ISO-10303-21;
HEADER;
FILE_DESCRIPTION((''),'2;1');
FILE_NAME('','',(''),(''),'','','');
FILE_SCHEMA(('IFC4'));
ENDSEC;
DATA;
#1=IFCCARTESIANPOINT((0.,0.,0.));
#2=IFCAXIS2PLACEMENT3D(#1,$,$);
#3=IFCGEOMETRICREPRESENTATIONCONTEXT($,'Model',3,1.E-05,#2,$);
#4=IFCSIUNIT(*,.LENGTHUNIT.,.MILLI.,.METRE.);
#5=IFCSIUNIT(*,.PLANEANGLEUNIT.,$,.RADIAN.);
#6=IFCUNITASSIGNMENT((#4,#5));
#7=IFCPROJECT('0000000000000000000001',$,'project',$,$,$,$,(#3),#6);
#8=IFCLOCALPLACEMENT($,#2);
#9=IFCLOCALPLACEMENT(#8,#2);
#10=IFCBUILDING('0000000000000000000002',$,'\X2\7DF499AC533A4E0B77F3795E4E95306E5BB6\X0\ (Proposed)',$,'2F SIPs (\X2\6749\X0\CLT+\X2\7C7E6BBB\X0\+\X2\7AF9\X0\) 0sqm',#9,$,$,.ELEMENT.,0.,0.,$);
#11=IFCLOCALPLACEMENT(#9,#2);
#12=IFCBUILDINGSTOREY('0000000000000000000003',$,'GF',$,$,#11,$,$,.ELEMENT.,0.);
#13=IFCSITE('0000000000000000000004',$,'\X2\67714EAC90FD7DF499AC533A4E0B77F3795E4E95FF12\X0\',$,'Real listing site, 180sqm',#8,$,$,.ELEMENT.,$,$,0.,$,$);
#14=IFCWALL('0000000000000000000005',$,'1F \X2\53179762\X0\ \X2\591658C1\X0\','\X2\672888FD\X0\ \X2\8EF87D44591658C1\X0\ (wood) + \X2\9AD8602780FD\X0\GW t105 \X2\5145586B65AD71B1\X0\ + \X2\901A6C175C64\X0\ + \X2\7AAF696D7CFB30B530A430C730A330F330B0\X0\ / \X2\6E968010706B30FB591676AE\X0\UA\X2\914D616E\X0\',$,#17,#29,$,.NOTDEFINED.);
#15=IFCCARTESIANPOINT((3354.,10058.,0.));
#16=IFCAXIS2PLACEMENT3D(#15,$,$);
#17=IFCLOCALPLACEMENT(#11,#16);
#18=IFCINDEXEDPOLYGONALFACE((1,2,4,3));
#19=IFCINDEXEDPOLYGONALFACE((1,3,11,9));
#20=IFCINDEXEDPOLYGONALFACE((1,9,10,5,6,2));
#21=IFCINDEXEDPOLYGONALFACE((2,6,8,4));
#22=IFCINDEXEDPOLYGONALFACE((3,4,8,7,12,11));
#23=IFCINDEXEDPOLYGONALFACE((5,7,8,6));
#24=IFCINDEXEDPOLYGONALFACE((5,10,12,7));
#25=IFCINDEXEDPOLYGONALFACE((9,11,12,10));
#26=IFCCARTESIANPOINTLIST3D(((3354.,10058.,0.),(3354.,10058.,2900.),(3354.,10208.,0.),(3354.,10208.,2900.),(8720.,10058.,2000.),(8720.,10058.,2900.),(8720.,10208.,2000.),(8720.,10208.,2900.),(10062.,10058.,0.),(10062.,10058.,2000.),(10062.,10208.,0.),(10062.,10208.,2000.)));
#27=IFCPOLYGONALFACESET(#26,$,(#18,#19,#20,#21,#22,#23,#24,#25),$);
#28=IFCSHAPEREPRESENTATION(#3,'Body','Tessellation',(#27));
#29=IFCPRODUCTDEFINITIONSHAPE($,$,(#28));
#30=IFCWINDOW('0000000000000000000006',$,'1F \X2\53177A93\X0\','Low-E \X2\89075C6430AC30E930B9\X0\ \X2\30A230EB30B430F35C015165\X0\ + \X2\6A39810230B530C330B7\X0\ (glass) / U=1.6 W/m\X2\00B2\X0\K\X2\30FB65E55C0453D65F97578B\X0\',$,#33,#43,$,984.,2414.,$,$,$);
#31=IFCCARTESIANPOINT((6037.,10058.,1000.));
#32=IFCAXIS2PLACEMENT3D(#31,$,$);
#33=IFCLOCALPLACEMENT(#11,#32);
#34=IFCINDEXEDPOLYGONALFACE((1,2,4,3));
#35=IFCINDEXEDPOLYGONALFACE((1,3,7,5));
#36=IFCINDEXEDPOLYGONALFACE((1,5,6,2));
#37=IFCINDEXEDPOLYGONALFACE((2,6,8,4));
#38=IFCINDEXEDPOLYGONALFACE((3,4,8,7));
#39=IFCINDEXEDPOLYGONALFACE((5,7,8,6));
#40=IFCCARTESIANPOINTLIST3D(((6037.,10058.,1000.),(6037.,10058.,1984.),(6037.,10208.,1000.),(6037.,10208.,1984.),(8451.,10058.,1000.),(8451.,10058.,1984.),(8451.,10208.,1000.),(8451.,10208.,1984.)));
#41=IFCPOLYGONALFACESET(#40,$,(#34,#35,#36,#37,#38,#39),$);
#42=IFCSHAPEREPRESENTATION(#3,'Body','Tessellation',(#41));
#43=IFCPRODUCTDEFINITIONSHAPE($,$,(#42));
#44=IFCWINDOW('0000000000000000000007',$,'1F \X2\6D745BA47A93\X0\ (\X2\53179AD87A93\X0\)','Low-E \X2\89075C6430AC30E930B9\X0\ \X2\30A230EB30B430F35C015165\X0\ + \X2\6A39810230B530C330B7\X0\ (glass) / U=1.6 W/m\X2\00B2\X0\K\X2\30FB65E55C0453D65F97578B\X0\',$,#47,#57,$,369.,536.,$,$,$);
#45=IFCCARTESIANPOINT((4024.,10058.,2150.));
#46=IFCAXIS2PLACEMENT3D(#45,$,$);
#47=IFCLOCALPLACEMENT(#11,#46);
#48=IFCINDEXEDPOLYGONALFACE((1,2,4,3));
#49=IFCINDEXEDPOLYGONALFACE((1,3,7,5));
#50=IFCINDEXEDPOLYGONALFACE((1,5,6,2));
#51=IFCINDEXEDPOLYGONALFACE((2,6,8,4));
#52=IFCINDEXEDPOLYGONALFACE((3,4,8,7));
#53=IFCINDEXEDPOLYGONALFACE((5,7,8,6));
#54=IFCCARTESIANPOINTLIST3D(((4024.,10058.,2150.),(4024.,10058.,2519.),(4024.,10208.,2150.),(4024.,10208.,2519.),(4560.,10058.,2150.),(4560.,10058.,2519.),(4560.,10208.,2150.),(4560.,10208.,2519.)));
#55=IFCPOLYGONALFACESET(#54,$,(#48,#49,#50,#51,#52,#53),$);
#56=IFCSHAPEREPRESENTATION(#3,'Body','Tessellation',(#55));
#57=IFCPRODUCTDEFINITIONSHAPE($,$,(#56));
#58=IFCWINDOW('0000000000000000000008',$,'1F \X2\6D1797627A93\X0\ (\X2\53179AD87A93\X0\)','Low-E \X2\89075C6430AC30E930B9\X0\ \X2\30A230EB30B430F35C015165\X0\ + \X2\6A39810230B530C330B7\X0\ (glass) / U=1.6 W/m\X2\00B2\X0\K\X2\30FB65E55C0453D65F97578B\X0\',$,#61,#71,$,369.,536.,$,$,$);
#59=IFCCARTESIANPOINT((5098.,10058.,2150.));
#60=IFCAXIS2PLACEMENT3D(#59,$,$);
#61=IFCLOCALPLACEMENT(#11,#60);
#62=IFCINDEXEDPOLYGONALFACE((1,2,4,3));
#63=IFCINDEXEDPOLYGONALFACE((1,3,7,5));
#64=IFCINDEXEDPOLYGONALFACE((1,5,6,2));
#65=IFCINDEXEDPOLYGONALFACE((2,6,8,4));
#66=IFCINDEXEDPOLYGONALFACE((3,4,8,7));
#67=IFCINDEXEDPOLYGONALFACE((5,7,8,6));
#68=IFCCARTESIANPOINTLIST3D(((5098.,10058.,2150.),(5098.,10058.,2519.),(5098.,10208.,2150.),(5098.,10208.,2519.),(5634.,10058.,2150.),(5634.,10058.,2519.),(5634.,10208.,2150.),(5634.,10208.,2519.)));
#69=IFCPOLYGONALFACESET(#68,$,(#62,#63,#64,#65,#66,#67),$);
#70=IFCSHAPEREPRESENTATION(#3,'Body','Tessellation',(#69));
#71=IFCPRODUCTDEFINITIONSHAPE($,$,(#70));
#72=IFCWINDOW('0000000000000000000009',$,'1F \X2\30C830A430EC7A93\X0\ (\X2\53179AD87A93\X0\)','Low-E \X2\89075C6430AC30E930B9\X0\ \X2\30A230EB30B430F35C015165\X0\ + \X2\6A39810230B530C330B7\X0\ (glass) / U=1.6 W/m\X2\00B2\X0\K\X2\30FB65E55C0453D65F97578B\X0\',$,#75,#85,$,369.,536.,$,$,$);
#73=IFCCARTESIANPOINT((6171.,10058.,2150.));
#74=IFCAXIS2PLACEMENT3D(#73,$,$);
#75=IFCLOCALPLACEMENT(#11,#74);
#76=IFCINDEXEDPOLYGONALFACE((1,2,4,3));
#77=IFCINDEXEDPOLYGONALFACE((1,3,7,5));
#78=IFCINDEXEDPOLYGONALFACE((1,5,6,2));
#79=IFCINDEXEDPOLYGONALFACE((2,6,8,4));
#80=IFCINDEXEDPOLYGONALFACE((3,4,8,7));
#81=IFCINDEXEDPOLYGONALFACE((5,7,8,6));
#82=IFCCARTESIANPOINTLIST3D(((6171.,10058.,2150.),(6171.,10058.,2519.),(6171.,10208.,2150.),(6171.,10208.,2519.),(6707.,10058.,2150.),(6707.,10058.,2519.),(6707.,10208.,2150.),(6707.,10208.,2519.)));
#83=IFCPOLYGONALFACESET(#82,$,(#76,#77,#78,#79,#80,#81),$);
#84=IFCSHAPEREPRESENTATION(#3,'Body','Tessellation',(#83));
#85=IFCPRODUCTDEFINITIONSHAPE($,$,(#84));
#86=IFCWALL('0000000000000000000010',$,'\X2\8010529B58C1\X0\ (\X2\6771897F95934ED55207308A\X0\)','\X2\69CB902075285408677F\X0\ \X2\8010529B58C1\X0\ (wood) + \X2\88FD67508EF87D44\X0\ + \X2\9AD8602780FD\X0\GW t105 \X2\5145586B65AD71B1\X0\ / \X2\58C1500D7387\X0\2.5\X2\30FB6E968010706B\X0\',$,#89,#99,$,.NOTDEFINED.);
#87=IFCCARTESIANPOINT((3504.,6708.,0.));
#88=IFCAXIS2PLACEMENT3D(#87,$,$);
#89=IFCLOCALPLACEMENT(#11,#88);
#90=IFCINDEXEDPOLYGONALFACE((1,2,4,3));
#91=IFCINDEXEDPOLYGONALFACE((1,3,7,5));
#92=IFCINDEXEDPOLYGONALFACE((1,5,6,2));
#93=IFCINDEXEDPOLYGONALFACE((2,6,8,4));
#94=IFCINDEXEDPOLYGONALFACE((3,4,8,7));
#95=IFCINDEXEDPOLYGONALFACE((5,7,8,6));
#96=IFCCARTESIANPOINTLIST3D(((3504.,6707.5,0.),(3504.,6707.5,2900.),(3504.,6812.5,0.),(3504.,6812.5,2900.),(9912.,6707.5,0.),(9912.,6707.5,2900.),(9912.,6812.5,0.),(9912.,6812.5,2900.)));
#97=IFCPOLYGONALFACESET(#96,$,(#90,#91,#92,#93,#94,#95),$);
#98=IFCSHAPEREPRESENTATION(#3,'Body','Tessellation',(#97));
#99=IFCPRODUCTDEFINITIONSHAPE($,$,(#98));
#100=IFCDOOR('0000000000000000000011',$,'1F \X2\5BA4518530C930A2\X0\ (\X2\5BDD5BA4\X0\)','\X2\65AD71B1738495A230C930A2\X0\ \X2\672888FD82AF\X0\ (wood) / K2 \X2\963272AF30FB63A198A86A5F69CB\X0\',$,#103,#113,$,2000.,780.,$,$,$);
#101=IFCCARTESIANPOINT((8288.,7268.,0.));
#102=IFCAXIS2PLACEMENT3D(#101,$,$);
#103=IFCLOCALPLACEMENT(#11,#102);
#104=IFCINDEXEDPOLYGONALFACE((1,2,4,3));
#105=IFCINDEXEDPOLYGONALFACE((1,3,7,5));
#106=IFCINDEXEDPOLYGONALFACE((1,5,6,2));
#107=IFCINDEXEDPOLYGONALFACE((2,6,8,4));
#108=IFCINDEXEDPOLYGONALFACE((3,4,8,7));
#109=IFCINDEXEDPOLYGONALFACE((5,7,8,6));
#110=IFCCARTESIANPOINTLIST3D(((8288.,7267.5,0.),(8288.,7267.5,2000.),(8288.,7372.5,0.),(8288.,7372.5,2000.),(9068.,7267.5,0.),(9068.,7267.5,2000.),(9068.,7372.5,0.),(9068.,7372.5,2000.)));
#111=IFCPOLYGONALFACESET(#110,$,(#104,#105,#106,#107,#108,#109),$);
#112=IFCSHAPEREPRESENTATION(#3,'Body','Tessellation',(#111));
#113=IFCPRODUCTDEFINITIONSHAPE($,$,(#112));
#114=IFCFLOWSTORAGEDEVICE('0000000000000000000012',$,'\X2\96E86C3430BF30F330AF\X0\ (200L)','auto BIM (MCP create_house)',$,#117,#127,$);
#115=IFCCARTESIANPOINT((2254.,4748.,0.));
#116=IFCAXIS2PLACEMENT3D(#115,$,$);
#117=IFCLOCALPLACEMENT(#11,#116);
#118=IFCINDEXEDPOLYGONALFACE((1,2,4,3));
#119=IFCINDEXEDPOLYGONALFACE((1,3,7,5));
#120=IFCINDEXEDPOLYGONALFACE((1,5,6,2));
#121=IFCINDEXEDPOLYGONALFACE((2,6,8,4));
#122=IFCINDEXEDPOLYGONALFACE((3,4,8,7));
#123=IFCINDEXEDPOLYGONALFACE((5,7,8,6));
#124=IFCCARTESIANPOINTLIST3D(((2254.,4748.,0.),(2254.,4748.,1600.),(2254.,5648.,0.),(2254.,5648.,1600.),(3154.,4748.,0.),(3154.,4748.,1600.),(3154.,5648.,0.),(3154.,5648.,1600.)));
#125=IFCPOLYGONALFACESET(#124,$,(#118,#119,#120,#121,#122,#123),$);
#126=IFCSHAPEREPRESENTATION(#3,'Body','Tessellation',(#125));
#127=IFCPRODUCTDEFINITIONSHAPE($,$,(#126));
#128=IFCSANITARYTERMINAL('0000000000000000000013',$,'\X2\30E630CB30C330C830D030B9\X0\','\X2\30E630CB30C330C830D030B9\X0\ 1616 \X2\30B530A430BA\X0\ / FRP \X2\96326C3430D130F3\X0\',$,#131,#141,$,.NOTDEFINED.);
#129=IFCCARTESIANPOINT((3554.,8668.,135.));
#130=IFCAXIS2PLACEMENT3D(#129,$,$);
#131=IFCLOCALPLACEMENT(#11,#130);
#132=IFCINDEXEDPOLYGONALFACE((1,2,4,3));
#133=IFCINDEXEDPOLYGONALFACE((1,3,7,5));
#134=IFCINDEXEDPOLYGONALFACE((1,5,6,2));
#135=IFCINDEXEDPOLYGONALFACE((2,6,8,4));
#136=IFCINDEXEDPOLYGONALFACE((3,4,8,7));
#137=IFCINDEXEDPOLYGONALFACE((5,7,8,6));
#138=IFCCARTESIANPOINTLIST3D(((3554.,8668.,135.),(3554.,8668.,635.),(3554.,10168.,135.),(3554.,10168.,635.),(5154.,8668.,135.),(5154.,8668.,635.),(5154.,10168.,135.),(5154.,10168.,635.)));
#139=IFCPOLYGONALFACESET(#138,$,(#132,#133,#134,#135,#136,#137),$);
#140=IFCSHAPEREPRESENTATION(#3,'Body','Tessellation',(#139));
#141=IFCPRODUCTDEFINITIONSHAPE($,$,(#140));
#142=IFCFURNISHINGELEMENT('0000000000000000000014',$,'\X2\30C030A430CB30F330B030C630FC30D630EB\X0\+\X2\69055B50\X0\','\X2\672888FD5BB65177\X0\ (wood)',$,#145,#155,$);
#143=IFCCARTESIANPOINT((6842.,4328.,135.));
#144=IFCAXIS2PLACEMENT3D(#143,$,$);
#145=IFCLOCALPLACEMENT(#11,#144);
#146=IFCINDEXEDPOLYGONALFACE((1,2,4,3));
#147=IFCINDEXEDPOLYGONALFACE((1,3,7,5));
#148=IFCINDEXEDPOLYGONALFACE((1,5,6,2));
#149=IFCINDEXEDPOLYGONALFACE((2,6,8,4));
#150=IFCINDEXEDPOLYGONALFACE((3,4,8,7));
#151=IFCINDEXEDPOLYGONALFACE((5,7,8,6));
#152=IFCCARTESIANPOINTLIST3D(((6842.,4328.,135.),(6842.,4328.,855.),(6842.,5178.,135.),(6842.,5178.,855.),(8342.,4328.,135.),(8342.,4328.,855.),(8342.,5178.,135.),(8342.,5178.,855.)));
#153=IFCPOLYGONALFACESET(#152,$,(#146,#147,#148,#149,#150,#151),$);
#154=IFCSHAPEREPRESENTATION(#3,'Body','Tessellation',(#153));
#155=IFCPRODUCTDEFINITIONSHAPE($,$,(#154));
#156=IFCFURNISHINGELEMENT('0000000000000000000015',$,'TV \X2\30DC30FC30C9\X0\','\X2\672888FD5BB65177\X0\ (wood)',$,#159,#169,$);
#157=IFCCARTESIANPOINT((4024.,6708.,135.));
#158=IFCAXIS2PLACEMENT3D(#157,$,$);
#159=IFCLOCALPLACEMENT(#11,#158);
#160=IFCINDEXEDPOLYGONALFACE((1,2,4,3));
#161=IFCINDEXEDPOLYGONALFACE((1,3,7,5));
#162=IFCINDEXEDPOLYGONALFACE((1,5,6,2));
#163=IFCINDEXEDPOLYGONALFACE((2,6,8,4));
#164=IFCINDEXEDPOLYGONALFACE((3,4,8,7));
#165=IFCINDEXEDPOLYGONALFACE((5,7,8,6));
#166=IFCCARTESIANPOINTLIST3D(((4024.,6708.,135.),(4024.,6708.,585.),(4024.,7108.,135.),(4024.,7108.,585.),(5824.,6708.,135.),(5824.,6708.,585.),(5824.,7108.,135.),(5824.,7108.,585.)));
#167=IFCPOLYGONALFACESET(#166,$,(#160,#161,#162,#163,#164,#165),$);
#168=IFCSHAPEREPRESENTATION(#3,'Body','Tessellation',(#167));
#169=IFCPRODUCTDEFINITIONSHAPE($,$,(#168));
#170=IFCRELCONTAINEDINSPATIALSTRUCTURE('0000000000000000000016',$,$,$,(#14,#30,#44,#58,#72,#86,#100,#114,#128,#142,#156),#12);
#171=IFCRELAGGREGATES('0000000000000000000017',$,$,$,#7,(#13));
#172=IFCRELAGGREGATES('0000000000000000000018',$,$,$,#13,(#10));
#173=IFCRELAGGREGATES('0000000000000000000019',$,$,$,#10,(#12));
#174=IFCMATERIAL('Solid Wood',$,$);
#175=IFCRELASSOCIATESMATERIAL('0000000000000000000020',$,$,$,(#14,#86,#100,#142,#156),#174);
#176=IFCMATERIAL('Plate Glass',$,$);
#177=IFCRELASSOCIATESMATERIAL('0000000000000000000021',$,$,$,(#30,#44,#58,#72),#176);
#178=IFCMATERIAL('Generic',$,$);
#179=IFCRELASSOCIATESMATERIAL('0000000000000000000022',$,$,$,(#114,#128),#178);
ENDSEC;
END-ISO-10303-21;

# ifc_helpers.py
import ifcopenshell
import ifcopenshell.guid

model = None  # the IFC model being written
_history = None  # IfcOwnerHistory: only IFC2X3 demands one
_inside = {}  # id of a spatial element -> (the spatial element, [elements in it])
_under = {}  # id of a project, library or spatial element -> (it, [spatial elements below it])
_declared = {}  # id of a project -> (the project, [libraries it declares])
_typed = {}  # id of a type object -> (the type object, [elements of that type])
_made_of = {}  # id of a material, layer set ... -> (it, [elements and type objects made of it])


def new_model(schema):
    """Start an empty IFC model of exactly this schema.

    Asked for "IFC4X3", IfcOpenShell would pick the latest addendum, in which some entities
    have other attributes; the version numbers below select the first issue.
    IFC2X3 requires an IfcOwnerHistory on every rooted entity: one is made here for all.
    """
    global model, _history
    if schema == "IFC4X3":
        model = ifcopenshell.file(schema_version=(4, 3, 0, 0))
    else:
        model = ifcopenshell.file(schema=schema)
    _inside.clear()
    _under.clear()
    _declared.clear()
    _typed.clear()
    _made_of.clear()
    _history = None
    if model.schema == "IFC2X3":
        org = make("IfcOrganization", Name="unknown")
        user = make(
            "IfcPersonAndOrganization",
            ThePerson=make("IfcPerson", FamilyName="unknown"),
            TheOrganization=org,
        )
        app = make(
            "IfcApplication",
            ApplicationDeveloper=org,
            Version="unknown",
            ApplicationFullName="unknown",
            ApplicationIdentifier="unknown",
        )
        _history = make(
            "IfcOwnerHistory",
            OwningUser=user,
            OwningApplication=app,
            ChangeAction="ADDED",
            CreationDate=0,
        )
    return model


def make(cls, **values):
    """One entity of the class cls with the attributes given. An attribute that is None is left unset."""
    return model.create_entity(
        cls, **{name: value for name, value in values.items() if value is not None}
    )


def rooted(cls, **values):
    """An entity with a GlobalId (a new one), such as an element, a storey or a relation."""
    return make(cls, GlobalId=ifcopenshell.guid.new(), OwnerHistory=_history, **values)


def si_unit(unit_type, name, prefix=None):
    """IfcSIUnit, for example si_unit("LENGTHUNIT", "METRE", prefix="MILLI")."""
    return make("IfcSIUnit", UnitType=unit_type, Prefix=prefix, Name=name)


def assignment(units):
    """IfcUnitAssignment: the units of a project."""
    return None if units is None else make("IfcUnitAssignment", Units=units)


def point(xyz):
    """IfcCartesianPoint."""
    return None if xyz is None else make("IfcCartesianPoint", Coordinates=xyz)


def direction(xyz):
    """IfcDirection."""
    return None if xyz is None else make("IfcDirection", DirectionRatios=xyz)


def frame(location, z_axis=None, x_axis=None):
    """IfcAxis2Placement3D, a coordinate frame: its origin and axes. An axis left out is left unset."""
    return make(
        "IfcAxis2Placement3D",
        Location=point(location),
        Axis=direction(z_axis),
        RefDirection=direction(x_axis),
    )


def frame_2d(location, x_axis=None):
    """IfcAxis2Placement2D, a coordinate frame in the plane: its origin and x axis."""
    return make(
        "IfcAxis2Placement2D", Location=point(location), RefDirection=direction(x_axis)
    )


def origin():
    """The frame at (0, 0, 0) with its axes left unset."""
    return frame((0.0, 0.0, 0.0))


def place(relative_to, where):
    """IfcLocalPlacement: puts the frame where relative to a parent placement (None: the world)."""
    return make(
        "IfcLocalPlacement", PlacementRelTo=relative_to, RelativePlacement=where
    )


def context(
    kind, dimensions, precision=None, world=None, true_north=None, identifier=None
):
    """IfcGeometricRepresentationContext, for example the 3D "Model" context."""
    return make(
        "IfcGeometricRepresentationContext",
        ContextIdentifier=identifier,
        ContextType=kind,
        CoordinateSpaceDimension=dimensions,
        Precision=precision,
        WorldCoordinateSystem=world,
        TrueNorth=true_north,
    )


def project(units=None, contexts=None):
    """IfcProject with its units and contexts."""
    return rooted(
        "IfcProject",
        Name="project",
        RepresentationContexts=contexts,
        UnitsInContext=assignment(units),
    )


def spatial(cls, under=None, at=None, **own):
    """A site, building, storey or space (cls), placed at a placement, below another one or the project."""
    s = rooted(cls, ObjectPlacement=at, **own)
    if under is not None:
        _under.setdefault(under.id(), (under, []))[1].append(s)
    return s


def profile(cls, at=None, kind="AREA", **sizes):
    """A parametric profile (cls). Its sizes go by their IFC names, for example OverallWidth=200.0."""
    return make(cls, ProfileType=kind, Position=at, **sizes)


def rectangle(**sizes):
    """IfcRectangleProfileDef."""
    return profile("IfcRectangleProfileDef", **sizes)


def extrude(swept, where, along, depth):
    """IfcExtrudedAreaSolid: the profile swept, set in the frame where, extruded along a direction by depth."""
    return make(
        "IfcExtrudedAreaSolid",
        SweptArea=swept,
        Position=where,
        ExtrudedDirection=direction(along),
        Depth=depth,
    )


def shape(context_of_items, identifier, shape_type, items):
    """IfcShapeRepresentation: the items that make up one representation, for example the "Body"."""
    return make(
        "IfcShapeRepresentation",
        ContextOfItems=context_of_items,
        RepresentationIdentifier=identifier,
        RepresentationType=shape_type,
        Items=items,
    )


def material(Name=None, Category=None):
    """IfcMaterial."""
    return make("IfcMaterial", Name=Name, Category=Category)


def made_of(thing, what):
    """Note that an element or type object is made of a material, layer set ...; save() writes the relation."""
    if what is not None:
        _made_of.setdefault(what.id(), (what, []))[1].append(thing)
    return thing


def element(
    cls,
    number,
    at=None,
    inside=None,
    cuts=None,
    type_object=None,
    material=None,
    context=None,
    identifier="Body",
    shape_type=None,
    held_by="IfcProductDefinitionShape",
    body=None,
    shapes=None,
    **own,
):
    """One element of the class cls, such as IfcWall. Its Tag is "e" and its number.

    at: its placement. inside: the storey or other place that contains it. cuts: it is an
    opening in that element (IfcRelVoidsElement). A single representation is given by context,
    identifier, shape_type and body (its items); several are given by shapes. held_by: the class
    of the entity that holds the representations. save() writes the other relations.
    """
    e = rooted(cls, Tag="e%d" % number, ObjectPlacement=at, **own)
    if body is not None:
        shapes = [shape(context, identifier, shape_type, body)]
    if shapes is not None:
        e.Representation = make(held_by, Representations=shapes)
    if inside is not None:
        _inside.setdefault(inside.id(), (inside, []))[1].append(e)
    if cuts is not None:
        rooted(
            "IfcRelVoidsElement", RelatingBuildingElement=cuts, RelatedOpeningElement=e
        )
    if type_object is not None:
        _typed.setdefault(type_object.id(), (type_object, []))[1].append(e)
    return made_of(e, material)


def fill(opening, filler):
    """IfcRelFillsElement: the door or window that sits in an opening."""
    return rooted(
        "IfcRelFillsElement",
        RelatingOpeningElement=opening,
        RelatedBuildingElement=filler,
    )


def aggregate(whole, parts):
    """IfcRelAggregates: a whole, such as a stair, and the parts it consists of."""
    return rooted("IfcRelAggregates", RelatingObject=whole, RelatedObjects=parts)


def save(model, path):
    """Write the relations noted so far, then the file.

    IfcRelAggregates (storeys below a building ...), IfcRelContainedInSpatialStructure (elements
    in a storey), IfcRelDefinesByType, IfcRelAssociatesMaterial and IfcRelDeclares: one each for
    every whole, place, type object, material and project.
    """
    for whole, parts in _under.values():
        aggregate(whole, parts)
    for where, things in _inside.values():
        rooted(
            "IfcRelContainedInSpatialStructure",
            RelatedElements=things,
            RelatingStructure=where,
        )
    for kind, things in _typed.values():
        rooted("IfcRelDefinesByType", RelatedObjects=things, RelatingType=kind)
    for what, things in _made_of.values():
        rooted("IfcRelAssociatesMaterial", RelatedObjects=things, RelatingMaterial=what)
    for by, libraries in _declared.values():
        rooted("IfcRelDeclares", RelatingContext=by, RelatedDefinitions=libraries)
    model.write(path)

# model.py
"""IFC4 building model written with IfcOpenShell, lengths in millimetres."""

from ifc_helpers import new_model, si_unit, frame, frame_2d, origin, place, context, project, spatial, rectangle, extrude, material, element, fill, save


model = new_model("IFC4")

# Units and contexts
model_context = context("Model", 3, precision=1e-05, world=origin())
ifc_project = project(units=[si_unit("LENGTHUNIT", "METRE", prefix="MILLI"), si_unit("PLANEANGLEUNIT", "RADIAN")], contexts=[model_context])

# Site, building, storey
site_placement = place(None, origin())
site = spatial("IfcSite", under=ifc_project, at=site_placement, Name="東京都練馬区下石神井２", ObjectType="Real listing site, 180sqm", CompositionType="ELEMENT", RefElevation=0.0)
building_placement = place(site_placement, origin())
building = spatial("IfcBuilding", under=site, at=building_placement, Name="練馬区下石神井の家 (Proposed)", ObjectType="2F SIPs (杉CLT+籾殻+竹) 0sqm", CompositionType="ELEMENT", ElevationOfRefHeight=0.0, ElevationOfTerrain=0.0)
storey_placement = place(building_placement, origin())
storey = spatial("IfcBuildingStorey", under=building, at=storey_placement, Name="GF", CompositionType="ELEMENT", Elevation=0.0)

# Wall, openings, windows
ifc_material_1 = material(Name="Solid Wood")
wall_1_placement = place(storey_placement, frame((3354.0, 10058.0, 0.0)))
wall_1 = element("IfcWall", 1, at=wall_1_placement, inside=storey, material=ifc_material_1, Name="1F 北面 外壁", Description="木製 軸組外壁 (wood) + 高性能GW t105 充填断熱 + 通気層 + 窯業系サイディング / 準耐火・外皮UA配慮", PredefinedType="NOTDEFINED", context=model_context, shape_type="SweptSolid", body=[
    extrude(rectangle(XDim=6708.0, YDim=150.0, at=frame_2d((3354.0, 75.0))), frame((3354.0, 10058.0, 0.0)), (0.0, 0.0, 1.0), 2900.0),
])
opening_1_placement = place(storey_placement, frame((6037.0, 10058.0, 1000.0)))
opening_1 = element("IfcOpeningElement", 2, at=opening_1_placement, cuts=wall_1, PredefinedType="NOTDEFINED", context=model_context, shape_type="SweptSolid", body=[
    extrude(rectangle(XDim=2414.0, YDim=150.0, at=frame_2d((1207.0, 75.0))), frame((6037.0, 10058.0, 1000.0)), (0.0, 0.0, 1.0), 984.0),
])
opening_2_placement = place(storey_placement, frame((4024.0, 10058.0, 2150.0)))
opening_2 = element("IfcOpeningElement", 3, at=opening_2_placement, cuts=wall_1, PredefinedType="NOTDEFINED", context=model_context, shape_type="SweptSolid", body=[
    extrude(rectangle(XDim=536.0, YDim=150.0, at=frame_2d((268.0, 75.0))), frame((4024.0, 10058.0, 2150.0)), (0.0, 0.0, 1.0), 369.0),
])
opening_3_placement = place(storey_placement, frame((5098.0, 10058.0, 2150.0)))
opening_3 = element("IfcOpeningElement", 4, at=opening_3_placement, cuts=wall_1, PredefinedType="NOTDEFINED", context=model_context, shape_type="SweptSolid", body=[
    extrude(rectangle(XDim=536.0, YDim=150.0, at=frame_2d((268.0, 75.0))), frame((5098.0, 10058.0, 2150.0)), (0.0, 0.0, 1.0), 369.0),
])
opening_4_placement = place(storey_placement, frame((6171.0, 10058.0, 2150.0)))
opening_4 = element("IfcOpeningElement", 5, at=opening_4_placement, cuts=wall_1, PredefinedType="NOTDEFINED", context=model_context, shape_type="SweptSolid", body=[
    extrude(rectangle(XDim=536.0, YDim=150.0, at=frame_2d((268.0, 75.0))), frame((6171.0, 10058.0, 2150.0)), (0.0, 0.0, 1.0), 369.0),
])
ifc_material_2 = material(Name="Plate Glass")
window_1_placement = place(storey_placement, frame((6037.0, 10058.0, 1000.0)))
window_1 = element("IfcWindow", 6, at=window_1_placement, inside=storey, material=ifc_material_2, Name="1F 北窓", Description="Low-E 複層ガラス アルゴン封入 + 樹脂サッシ (glass) / U=1.6 W/m²K・日射取得型", OverallHeight=984.0, OverallWidth=2414.0, context=model_context, shape_type="SweptSolid", body=[
    extrude(rectangle(XDim=2414.0, YDim=150.0, at=frame_2d((1207.0, 75.0))), frame((6037.0, 10058.0, 1000.0)), (0.0, 0.0, 1.0), 984.0),
])
fill(opening_1, window_1)
window_2_placement = place(storey_placement, frame((4024.0, 10058.0, 2150.0)))
window_2 = element("IfcWindow", 7, at=window_2_placement, inside=storey, material=ifc_material_2, Name="1F 浴室窓 (北高窓)", Description="Low-E 複層ガラス アルゴン封入 + 樹脂サッシ (glass) / U=1.6 W/m²K・日射取得型", OverallHeight=369.0, OverallWidth=536.0, context=model_context, shape_type="SweptSolid", body=[
    extrude(rectangle(XDim=536.0, YDim=150.0, at=frame_2d((268.0, 75.0))), frame((4024.0, 10058.0, 2150.0)), (0.0, 0.0, 1.0), 369.0),
])
fill(opening_2, window_2)
window_3_placement = place(storey_placement, frame((5098.0, 10058.0, 2150.0)))
window_3 = element("IfcWindow", 8, at=window_3_placement, inside=storey, material=ifc_material_2, Name="1F 洗面窓 (北高窓)", Description="Low-E 複層ガラス アルゴン封入 + 樹脂サッシ (glass) / U=1.6 W/m²K・日射取得型", OverallHeight=369.0, OverallWidth=536.0, context=model_context, shape_type="SweptSolid", body=[
    extrude(rectangle(XDim=536.0, YDim=150.0, at=frame_2d((268.0, 75.0))), frame((5098.0, 10058.0, 2150.0)), (0.0, 0.0, 1.0), 369.0),
])
fill(opening_3, window_3)
window_4_placement = place(storey_placement, frame((6171.0, 10058.0, 2150.0)))
window_4 = element("IfcWindow", 9, at=window_4_placement, inside=storey, material=ifc_material_2, Name="1F トイレ窓 (北高窓)", Description="Low-E 複層ガラス アルゴン封入 + 樹脂サッシ (glass) / U=1.6 W/m²K・日射取得型", OverallHeight=369.0, OverallWidth=536.0, context=model_context, shape_type="SweptSolid", body=[
    extrude(rectangle(XDim=536.0, YDim=150.0, at=frame_2d((268.0, 75.0))), frame((6171.0, 10058.0, 2150.0)), (0.0, 0.0, 1.0), 369.0),
])
fill(opening_4, window_4)

# Wall
wall_2_placement = place(storey_placement, frame((3504.0, 6708.0, 0.0)))
element("IfcWall", 10, at=wall_2_placement, inside=storey, material=ifc_material_1, Name="耐力壁 (東西間仕切り)", Description="構造用合板 耐力壁 (wood) + 製材軸組 + 高性能GW t105 充填断熱 / 壁倍率2.5・準耐火", PredefinedType="NOTDEFINED", context=model_context, shape_type="SweptSolid", body=[
    extrude(rectangle(XDim=6408.0, YDim=105.0, at=frame_2d((3204.0, 52.0))), frame((3504.0, 6708.0, 0.0)), (0.0, 0.0, 1.0), 2900.0),
])

# Door
door_1_placement = place(storey_placement, frame((8288.0, 7268.0, 0.0)))
element("IfcDoor", 11, at=door_1_placement, inside=storey, material=ifc_material_1, Name="1F 室内ドア (寝室)", Description="断熱玄関ドア 木製芯 (wood) / K2 防犯・採風機構", OverallHeight=2000.0, OverallWidth=780.0, context=model_context, shape_type="SweptSolid", body=[
    extrude(rectangle(XDim=780.0, YDim=105.0, at=frame_2d((390.0, 52.0))), frame((8288.0, 7268.0, 0.0)), (0.0, 0.0, 1.0), 2000.0),
])

# Flow storage device
ifc_material_3 = material(Name="Generic")
flow_storage_device_placement = place(storey_placement, frame((2254.0, 4748.0, 0.0)))
element("IfcFlowStorageDevice", 12, at=flow_storage_device_placement, inside=storey, material=ifc_material_3, Name="雨水タンク (200L)", Description="auto BIM (MCP create_house)", context=model_context, shape_type="SweptSolid", body=[
    extrude(rectangle(XDim=900.0, YDim=900.0, at=frame_2d((450.0, 450.0))), frame((2254.0, 4748.0, 0.0)), (0.0, 0.0, 1.0), 1600.0),
])

# Sanitary terminal
sanitary_terminal_placement = place(storey_placement, frame((3554.0, 8668.0, 135.0)))
element("IfcSanitaryTerminal", 13, at=sanitary_terminal_placement, inside=storey, material=ifc_material_3, Name="ユニットバス", Description="ユニットバス 1616 サイズ / FRP 防水パン", PredefinedType="NOTDEFINED", context=model_context, shape_type="SweptSolid", body=[
    extrude(rectangle(XDim=1600.0, YDim=1500.0, at=frame_2d((800.0, 750.0))), frame((3554.0, 8668.0, 135.0)), (0.0, 0.0, 1.0), 500.0),
])

# Furnishing elements
furnishing_1_placement = place(storey_placement, frame((6842.0, 4328.0, 135.0)))
element("IfcFurnishingElement", 14, at=furnishing_1_placement, inside=storey, material=ifc_material_1, Name="ダイニングテーブル+椅子", Description="木製家具 (wood)", context=model_context, shape_type="SweptSolid", body=[
    extrude(rectangle(XDim=1500.0, YDim=850.0, at=frame_2d((750.0, 425.0))), frame((6842.0, 4328.0, 135.0)), (0.0, 0.0, 1.0), 720.0),
])
furnishing_2_placement = place(storey_placement, frame((4024.0, 6708.0, 135.0)))
element("IfcFurnishingElement", 15, at=furnishing_2_placement, inside=storey, material=ifc_material_1, Name="TV ボード", Description="木製家具 (wood)", context=model_context, shape_type="SweptSolid", body=[
    extrude(rectangle(XDim=1800.0, YDim=400.0, at=frame_2d((900.0, 200.0))), frame((4024.0, 6708.0, 135.0)), (0.0, 0.0, 1.0), 450.0),
])

save(model, "model.ifc")
